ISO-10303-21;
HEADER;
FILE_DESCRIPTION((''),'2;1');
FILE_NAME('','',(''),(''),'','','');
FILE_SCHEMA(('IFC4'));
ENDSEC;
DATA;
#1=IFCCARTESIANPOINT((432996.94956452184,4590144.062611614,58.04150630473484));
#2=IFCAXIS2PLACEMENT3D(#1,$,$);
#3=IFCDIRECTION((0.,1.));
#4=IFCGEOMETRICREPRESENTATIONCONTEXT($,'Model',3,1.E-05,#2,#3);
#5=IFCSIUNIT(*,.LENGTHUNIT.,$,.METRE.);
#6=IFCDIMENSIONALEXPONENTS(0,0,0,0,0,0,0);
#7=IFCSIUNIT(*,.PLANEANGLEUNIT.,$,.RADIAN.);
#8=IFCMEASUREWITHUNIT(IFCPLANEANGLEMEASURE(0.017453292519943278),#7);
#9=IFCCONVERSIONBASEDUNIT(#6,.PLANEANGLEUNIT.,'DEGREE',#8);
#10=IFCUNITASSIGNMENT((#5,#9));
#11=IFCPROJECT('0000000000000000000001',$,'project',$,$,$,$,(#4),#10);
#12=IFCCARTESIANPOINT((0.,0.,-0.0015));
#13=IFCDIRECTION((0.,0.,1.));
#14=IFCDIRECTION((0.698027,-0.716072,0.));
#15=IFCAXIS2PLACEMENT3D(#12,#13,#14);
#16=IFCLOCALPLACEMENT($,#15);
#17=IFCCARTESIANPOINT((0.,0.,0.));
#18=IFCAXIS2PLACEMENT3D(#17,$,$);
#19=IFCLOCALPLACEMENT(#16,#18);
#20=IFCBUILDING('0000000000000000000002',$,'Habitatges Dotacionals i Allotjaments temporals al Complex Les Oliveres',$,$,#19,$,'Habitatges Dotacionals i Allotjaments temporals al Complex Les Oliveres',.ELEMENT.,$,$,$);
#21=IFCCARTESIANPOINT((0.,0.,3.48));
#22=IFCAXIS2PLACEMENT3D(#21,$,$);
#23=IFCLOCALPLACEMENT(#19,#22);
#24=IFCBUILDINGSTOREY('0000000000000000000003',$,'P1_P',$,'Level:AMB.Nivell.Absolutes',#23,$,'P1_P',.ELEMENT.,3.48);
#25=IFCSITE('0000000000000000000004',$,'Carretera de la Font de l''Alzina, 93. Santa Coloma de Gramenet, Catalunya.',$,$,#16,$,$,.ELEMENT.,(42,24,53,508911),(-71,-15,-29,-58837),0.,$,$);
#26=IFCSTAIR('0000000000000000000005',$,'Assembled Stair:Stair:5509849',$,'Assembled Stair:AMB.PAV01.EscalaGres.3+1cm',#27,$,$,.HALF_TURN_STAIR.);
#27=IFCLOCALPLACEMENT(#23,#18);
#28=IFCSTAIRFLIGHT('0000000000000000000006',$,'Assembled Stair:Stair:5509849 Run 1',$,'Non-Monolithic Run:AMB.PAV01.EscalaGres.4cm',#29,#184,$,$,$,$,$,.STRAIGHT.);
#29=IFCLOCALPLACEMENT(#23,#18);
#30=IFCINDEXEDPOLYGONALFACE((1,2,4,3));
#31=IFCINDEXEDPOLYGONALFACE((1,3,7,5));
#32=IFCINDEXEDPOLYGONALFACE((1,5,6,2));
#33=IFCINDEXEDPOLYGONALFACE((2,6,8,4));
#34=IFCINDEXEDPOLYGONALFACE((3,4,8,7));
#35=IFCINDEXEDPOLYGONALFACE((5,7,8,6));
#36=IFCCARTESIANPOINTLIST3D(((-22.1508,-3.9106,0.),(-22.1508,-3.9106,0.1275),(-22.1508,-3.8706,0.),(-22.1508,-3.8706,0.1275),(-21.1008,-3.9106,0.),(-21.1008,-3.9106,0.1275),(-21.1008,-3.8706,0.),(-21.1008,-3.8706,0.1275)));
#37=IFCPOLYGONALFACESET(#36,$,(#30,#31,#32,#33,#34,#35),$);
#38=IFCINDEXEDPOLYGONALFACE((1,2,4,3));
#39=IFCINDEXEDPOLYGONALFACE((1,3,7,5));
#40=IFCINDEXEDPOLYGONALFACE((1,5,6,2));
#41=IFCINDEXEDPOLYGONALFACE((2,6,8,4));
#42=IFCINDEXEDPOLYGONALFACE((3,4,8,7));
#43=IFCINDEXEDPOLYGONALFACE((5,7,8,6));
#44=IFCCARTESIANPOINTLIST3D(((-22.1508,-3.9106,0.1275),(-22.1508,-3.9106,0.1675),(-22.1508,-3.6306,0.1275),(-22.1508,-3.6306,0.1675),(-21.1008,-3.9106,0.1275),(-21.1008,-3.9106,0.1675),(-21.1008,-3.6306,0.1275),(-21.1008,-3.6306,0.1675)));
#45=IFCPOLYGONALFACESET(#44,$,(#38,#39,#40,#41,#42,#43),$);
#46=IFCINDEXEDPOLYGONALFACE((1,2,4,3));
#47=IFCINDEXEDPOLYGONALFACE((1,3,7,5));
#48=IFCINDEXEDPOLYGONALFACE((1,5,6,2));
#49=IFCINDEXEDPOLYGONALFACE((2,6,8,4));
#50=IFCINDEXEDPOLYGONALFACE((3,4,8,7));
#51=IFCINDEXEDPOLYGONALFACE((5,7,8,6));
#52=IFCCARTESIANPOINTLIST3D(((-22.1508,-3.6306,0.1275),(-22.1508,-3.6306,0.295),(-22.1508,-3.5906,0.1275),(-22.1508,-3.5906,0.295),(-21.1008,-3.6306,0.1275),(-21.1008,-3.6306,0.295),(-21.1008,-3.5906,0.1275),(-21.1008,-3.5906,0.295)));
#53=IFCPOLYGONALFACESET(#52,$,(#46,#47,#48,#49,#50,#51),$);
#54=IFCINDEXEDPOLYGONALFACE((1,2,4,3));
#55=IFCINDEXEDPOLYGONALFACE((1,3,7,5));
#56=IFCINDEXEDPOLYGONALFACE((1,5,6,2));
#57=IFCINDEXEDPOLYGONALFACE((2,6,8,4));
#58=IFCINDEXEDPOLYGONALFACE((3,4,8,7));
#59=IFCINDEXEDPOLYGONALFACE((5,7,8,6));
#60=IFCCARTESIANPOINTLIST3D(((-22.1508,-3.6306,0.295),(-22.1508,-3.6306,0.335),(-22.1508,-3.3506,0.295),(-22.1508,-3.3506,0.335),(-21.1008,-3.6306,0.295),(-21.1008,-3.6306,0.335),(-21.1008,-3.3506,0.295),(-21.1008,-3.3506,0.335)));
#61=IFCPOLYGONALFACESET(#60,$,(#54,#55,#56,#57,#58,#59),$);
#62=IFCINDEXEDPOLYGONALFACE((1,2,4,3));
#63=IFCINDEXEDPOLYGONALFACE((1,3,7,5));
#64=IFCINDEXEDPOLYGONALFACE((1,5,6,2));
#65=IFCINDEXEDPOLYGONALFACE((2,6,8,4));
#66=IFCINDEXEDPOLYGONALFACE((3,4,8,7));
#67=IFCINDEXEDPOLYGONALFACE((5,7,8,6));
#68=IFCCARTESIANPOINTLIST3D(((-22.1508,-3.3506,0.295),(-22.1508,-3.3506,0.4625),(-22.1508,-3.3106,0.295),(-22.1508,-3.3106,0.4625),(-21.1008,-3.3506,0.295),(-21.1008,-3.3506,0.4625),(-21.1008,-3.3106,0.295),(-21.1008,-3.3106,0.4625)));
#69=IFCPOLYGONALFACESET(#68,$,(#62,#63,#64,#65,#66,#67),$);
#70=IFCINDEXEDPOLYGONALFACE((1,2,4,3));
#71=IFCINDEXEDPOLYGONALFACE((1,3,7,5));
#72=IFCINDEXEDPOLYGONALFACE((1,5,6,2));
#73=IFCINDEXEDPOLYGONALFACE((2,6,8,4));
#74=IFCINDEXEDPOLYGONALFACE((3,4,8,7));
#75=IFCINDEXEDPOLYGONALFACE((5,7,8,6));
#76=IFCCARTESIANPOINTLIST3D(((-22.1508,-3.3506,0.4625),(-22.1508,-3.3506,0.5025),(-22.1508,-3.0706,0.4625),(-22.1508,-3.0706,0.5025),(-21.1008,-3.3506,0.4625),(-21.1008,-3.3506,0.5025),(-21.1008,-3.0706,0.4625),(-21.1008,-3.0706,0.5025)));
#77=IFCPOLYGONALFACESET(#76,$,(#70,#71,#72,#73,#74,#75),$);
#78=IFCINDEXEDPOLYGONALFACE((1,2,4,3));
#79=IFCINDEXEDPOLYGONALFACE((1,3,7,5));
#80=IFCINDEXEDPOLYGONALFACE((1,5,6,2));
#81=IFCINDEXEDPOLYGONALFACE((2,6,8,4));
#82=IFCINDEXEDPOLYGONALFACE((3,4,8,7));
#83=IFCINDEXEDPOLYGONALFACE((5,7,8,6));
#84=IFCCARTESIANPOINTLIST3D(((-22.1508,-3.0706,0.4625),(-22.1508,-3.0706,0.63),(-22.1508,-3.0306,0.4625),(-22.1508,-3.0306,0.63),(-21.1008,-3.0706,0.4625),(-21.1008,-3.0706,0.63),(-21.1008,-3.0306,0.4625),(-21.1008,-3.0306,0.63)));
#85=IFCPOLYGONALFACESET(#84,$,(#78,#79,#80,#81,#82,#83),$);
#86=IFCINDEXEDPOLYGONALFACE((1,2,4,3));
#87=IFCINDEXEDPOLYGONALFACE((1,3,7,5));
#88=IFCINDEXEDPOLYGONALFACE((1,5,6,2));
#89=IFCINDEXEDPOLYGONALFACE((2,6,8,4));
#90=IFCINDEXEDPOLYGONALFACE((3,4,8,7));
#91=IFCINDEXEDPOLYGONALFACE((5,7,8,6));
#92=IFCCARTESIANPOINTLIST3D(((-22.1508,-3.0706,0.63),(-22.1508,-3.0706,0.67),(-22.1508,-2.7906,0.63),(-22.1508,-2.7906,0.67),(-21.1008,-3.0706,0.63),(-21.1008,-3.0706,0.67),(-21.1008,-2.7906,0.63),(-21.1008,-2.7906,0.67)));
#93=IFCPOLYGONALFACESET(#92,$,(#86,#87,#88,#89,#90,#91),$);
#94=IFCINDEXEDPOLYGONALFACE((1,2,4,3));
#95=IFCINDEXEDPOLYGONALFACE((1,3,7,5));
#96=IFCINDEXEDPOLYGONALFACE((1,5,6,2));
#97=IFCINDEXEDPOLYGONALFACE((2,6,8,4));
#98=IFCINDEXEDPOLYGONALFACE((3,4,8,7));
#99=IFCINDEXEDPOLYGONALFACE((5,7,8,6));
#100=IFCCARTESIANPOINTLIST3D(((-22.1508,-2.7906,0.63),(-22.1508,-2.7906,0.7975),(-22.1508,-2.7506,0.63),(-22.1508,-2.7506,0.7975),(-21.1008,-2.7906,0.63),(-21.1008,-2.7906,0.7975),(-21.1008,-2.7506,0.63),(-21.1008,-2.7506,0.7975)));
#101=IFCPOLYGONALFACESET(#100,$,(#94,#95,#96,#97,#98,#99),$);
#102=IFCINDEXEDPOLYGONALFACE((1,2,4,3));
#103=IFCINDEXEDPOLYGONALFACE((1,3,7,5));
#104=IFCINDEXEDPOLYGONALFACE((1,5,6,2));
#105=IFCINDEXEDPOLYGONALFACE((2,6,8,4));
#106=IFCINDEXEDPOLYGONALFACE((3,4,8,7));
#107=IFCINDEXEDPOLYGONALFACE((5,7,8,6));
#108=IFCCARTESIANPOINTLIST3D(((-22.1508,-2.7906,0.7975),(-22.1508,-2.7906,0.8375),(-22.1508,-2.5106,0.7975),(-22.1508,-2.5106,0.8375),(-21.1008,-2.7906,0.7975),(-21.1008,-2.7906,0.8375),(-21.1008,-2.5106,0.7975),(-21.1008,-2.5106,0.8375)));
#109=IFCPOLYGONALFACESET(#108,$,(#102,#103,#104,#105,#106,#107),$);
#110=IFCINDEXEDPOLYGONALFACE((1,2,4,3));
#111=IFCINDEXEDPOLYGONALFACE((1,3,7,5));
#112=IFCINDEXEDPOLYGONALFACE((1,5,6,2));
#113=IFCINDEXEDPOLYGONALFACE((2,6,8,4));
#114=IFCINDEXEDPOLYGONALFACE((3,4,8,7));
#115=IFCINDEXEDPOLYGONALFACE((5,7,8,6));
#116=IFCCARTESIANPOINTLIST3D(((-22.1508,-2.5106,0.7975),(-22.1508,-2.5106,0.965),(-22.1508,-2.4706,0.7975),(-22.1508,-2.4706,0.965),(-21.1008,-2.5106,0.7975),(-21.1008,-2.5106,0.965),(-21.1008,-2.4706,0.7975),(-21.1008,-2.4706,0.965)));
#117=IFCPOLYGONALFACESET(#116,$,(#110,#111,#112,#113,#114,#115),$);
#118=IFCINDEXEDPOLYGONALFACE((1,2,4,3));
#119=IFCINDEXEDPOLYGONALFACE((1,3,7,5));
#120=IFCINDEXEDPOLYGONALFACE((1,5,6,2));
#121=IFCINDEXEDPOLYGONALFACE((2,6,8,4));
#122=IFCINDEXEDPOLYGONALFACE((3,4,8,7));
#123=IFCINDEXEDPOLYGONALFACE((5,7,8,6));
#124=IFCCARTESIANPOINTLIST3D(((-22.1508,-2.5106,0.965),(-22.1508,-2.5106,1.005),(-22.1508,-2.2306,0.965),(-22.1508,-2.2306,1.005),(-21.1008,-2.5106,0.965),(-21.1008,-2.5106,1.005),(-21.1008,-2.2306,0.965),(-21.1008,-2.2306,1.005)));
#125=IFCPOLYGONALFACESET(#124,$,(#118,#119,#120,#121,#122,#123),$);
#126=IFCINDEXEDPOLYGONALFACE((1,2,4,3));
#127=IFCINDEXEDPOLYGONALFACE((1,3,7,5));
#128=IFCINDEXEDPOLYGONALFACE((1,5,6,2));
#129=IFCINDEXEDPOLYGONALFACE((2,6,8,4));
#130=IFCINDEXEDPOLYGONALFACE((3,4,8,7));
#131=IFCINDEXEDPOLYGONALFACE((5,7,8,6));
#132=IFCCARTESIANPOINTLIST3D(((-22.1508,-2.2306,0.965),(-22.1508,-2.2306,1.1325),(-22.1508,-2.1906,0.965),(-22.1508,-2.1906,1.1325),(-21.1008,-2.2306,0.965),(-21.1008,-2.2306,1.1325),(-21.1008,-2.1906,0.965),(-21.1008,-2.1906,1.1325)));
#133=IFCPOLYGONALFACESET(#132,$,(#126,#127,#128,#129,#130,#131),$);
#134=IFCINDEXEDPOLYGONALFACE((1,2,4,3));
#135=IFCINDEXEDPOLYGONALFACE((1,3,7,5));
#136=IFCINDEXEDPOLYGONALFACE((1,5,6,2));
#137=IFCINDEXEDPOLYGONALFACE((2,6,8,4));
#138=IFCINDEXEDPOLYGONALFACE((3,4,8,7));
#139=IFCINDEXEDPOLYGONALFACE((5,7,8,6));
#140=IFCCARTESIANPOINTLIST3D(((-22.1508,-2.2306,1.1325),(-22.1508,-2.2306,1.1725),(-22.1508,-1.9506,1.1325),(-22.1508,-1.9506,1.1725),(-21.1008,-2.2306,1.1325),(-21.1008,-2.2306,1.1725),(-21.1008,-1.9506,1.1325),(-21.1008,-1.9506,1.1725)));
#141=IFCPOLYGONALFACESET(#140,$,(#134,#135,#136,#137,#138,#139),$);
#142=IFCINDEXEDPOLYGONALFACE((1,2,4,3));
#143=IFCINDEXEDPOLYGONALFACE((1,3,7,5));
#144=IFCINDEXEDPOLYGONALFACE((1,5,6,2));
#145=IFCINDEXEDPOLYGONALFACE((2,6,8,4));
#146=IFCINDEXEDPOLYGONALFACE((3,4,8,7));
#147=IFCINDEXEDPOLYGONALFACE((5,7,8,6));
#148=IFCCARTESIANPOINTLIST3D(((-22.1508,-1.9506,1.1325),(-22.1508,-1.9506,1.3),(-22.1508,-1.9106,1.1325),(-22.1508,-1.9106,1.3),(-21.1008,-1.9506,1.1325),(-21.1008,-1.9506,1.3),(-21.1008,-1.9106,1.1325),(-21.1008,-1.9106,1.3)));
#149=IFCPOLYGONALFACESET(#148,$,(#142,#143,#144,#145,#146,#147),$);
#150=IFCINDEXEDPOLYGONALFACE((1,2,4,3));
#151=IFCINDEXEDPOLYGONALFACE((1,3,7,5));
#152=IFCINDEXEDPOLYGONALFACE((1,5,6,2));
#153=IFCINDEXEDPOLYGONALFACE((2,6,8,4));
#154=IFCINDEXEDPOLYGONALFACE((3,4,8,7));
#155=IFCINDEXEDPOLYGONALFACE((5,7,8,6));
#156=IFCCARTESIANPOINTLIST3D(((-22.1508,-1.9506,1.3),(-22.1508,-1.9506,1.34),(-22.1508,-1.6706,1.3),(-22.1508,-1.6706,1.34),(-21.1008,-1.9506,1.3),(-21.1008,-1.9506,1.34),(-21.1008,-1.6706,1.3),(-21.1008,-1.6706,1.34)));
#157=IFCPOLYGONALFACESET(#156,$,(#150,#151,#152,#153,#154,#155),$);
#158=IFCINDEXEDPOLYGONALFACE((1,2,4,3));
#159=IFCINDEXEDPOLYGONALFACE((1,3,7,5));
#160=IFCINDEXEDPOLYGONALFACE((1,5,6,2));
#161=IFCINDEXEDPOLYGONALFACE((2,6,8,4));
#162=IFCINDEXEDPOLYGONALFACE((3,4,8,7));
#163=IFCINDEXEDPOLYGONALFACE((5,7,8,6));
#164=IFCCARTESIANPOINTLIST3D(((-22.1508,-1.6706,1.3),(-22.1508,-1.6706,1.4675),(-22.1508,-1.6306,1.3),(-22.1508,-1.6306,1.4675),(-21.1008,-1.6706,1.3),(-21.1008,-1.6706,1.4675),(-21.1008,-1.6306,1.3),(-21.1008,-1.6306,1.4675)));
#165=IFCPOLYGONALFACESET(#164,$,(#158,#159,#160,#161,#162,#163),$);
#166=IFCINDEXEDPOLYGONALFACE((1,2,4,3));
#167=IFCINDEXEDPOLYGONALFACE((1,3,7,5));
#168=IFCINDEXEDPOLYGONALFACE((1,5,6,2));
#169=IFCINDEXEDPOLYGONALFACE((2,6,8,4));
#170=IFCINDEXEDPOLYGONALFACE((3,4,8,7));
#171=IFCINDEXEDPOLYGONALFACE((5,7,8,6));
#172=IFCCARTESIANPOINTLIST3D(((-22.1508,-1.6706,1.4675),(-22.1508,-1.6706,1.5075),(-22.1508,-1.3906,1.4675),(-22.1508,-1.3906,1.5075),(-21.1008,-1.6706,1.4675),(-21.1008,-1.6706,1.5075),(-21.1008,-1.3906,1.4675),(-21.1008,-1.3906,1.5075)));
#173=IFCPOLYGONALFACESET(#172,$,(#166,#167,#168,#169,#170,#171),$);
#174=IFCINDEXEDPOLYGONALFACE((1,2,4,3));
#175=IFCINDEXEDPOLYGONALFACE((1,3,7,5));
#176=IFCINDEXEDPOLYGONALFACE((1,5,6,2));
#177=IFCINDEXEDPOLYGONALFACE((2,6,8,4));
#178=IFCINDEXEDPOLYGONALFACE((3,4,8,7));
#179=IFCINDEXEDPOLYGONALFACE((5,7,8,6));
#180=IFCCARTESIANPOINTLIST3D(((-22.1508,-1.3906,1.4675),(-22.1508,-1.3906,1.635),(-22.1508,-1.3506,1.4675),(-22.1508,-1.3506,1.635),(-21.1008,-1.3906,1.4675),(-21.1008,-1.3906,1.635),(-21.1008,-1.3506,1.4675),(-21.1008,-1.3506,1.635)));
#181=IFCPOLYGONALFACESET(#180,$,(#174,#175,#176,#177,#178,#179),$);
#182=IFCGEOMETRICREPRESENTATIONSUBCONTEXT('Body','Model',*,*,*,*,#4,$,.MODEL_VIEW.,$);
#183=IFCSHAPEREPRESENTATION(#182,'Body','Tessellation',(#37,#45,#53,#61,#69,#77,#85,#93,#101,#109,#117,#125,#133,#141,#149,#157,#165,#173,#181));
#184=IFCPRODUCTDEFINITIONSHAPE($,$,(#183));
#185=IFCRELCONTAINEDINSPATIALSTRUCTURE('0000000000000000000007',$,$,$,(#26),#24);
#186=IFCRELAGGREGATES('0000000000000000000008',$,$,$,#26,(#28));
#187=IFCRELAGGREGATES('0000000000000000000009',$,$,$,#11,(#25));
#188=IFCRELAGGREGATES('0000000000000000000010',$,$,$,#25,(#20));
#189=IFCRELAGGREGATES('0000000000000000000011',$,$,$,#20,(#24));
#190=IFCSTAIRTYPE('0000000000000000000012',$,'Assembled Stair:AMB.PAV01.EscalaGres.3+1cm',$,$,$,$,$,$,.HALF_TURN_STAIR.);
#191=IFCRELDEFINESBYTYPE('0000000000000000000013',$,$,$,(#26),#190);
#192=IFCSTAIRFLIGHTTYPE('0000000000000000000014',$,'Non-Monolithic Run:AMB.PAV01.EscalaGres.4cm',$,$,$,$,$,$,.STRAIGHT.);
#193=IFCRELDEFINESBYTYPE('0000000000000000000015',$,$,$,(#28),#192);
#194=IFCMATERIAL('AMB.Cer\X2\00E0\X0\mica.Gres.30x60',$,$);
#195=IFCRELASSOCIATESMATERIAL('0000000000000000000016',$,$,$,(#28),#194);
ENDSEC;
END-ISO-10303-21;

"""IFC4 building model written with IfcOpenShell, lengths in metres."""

from ifc_helpers import new_model, entity, si_unit, converted_unit, direction, frame, origin, place, context, subcontext, project, spatial, indexed_curve, outline, extrude, material, type_object, element, aggregate, save


model = new_model("IFC4")

# Units and contexts
model_context = context("Model", 3, precision=1e-05, world=frame((432996.94956452184, 4590144.062611614, 58.04150630473484)), true_north=direction((0.0, 1.0)))
body_context = subcontext(model_context, "Body", "Model", "MODEL_VIEW")
ifc_project = project(units=[si_unit("LENGTHUNIT", "METRE"), converted_unit("PLANEANGLEUNIT", "DEGREE", entity("IfcPlaneAngleMeasure", 0.017453292519943278), si_unit("PLANEANGLEUNIT", "RADIAN"), dimensions=[0, 0, 0, 0, 0, 0, 0])], contexts=[model_context])

# Site, building, storey
site_placement = place(None, frame((0.0, 0.0, -0.0015), z_axis=(0.0, 0.0, 1.0), x_axis=(0.698027, -0.716072, 0.0)))
site = spatial("IfcSite", under=ifc_project, at=site_placement, Name="Carretera de la Font de l'Alzina, 93. Santa Coloma de Gramenet, Catalunya.", CompositionType="ELEMENT", RefLatitude=(42, 24, 53, 508911), RefLongitude=(-71, -15, -29, -58837), RefElevation=0.0)
building_placement = place(site_placement, origin())
building = spatial("IfcBuilding", under=site, at=building_placement, Name="Habitatges Dotacionals i Allotjaments temporals al Complex Les Oliveres", LongName="Habitatges Dotacionals i Allotjaments temporals al Complex Les Oliveres", CompositionType="ELEMENT")
storey_placement = place(building_placement, frame((0.0, 0.0, 3.48)))
storey = spatial("IfcBuildingStorey", under=building, at=storey_placement, Name="P1_P", ObjectType="Level:AMB.Nivell.Absolutes", LongName="P1_P", CompositionType="ELEMENT", Elevation=3.48)

# Stair
stair_type_1 = type_object("IfcStairType", Name="Assembled Stair:AMB.PAV01.EscalaGres.3+1cm", PredefinedType="HALF_TURN_STAIR")
stair_1_placement = place(storey_placement, origin())
stair_1 = element("IfcStair", 1, at=stair_1_placement, inside=storey, type_object=stair_type_1, Name="Assembled Stair:Stair:5509849", ObjectType="Assembled Stair:AMB.PAV01.EscalaGres.3+1cm", PredefinedType="HALF_TURN_STAIR")
ifc_material_1 = material(Name="AMB.Ceràmica.Gres.30x60")

# Shared definitions
stair_flight_type = type_object("IfcStairFlightType", Name="Non-Monolithic Run:AMB.PAV01.EscalaGres.4cm", PredefinedType="STRAIGHT")

# Stair flight
stair_flight_1_placement = place(stair_1_placement, origin())
stair_flight_1 = element("IfcStairFlight", 2, at=stair_flight_1_placement, type_object=stair_flight_type, material=ifc_material_1, Name="Assembled Stair:Stair:5509849 Run 1", ObjectType="Non-Monolithic Run:AMB.PAV01.EscalaGres.4cm", PredefinedType="STRAIGHT", context=body_context, shape_type="SweptSolid", body=[
    extrude(outline(indexed_curve([(-0.525, -0.02), (0.525, -0.02), (0.525, 0.02), (-0.525, 0.02), (-0.525, -0.02)], self_intersect=False)), frame((-21.6258, -3.8906, 0.0), z_axis=(0.0, 0.0, 1.0), x_axis=(-1.0, 0.0, 0.0)), (0.0, 0.0, 1.0), 0.1275),
    extrude(outline(indexed_curve([(-0.14, -0.525), (0.14, -0.525), (0.14, 0.525), (-0.14, 0.525), (-0.14, -0.525)], self_intersect=False)), frame((-21.6258, -3.7706, 0.1275), z_axis=(0.0, 0.0, 1.0), x_axis=(0.0, -1.0, 0.0)), (0.0, 0.0, 1.0), 0.04),
    extrude(outline(indexed_curve([(-0.525, -0.02), (0.525, -0.02), (0.525, 0.02), (-0.525, 0.02), (-0.525, -0.02)], self_intersect=False)), frame((-21.6258, -3.6106, 0.1275), z_axis=(0.0, 0.0, 1.0), x_axis=(-1.0, 0.0, 0.0)), (0.0, 0.0, 1.0), 0.1675),
    extrude(outline(indexed_curve([(-0.14, -0.525), (0.14, -0.525), (0.14, 0.525), (-0.14, 0.525), (-0.14, -0.525)], self_intersect=False)), frame((-21.6258, -3.4906, 0.295), z_axis=(0.0, 0.0, 1.0), x_axis=(0.0, -1.0, 0.0)), (0.0, 0.0, 1.0), 0.04),
    extrude(outline(indexed_curve([(-0.525, -0.02), (0.525, -0.02), (0.525, 0.02), (-0.525, 0.02), (-0.525, -0.02)], self_intersect=False)), frame((-21.6258, -3.3306, 0.295), z_axis=(0.0, 0.0, 1.0), x_axis=(-1.0, 0.0, 0.0)), (0.0, 0.0, 1.0), 0.1675),
    extrude(outline(indexed_curve([(-0.14, -0.525), (0.14, -0.525), (0.14, 0.525), (-0.14, 0.525), (-0.14, -0.525)], self_intersect=False)), frame((-21.6258, -3.2106, 0.4625), z_axis=(0.0, 0.0, 1.0), x_axis=(0.0, -1.0, 0.0)), (0.0, 0.0, 1.0), 0.04),
    extrude(outline(indexed_curve([(-0.525, -0.02), (0.525, -0.02), (0.525, 0.02), (-0.525, 0.02), (-0.525, -0.02)], self_intersect=False)), frame((-21.6258, -3.0506, 0.4625), z_axis=(0.0, 0.0, 1.0), x_axis=(-1.0, 0.0, 0.0)), (0.0, 0.0, 1.0), 0.1675),
    extrude(outline(indexed_curve([(-0.14, -0.525), (0.14, -0.525), (0.14, 0.525), (-0.14, 0.525), (-0.14, -0.525)], self_intersect=False)), frame((-21.6258, -2.9306, 0.63), z_axis=(0.0, 0.0, 1.0), x_axis=(0.0, -1.0, 0.0)), (0.0, 0.0, 1.0), 0.04),
    extrude(outline(indexed_curve([(-0.525, -0.02), (0.525, -0.02), (0.525, 0.02), (-0.525, 0.02), (-0.525, -0.02)], self_intersect=False)), frame((-21.6258, -2.7706, 0.63), z_axis=(0.0, 0.0, 1.0), x_axis=(-1.0, 0.0, 0.0)), (0.0, 0.0, 1.0), 0.1675),
    extrude(outline(indexed_curve([(-0.14, -0.525), (0.14, -0.525), (0.14, 0.525), (-0.14, 0.525), (-0.14, -0.525)], self_intersect=False)), frame((-21.6258, -2.6506, 0.7975), z_axis=(0.0, 0.0, 1.0), x_axis=(0.0, -1.0, 0.0)), (0.0, 0.0, 1.0), 0.04),
    extrude(outline(indexed_curve([(-0.525, -0.02), (0.525, -0.02), (0.525, 0.02), (-0.525, 0.02), (-0.525, -0.02)], self_intersect=False)), frame((-21.6258, -2.4906, 0.7975), z_axis=(0.0, 0.0, 1.0), x_axis=(-1.0, 0.0, 0.0)), (0.0, 0.0, 1.0), 0.1675),
    extrude(outline(indexed_curve([(-0.14, -0.525), (0.14, -0.525), (0.14, 0.525), (-0.14, 0.525), (-0.14, -0.525)], self_intersect=False)), frame((-21.6258, -2.3706, 0.965), z_axis=(0.0, 0.0, 1.0), x_axis=(0.0, -1.0, 0.0)), (0.0, 0.0, 1.0), 0.04),
    extrude(outline(indexed_curve([(-0.525, -0.02), (0.525, -0.02), (0.525, 0.02), (-0.525, 0.02), (-0.525, -0.02)], self_intersect=False)), frame((-21.6258, -2.2106, 0.965), z_axis=(0.0, 0.0, 1.0), x_axis=(-1.0, 0.0, 0.0)), (0.0, 0.0, 1.0), 0.1675),
    extrude(outline(indexed_curve([(-0.14, -0.525), (0.14, -0.525), (0.14, 0.525), (-0.14, 0.525), (-0.14, -0.525)], self_intersect=False)), frame((-21.6258, -2.0906, 1.1325), z_axis=(0.0, 0.0, 1.0), x_axis=(0.0, -1.0, 0.0)), (0.0, 0.0, 1.0), 0.04),
    extrude(outline(indexed_curve([(-0.525, -0.02), (0.525, -0.02), (0.525, 0.02), (-0.525, 0.02), (-0.525, -0.02)], self_intersect=False)), frame((-21.6258, -1.9306, 1.1325), z_axis=(0.0, 0.0, 1.0), x_axis=(-1.0, 0.0, 0.0)), (0.0, 0.0, 1.0), 0.1675),
    extrude(outline(indexed_curve([(-0.14, -0.525), (0.14, -0.525), (0.14, 0.525), (-0.14, 0.525), (-0.14, -0.525)], self_intersect=False)), frame((-21.6258, -1.8106, 1.3), z_axis=(0.0, 0.0, 1.0), x_axis=(0.0, -1.0, 0.0)), (0.0, 0.0, 1.0), 0.04),
    extrude(outline(indexed_curve([(-0.525, -0.02), (0.525, -0.02), (0.525, 0.02), (-0.525, 0.02), (-0.525, -0.02)], self_intersect=False)), frame((-21.6258, -1.6506, 1.3), z_axis=(0.0, 0.0, 1.0), x_axis=(-1.0, 0.0, 0.0)), (0.0, 0.0, 1.0), 0.1675),
    extrude(outline(indexed_curve([(-0.14, -0.525), (0.14, -0.525), (0.14, 0.525), (-0.14, 0.525), (-0.14, -0.525)], self_intersect=False)), frame((-21.6258, -1.5306, 1.4675), z_axis=(0.0, 0.0, 1.0), x_axis=(0.0, -1.0, 0.0)), (0.0, 0.0, 1.0), 0.04),
    extrude(outline(indexed_curve([(-0.525, -0.02), (0.525, -0.02), (0.525, 0.02), (-0.525, 0.02), (-0.525, -0.02)], self_intersect=False)), frame((-21.6258, -1.3706, 1.4675), z_axis=(0.0, 0.0, 1.0), x_axis=(-1.0, 0.0, 0.0)), (0.0, 0.0, 1.0), 0.1675),
])
aggregate(stair_1, [stair_flight_1])

save(model, "model.ifc")
